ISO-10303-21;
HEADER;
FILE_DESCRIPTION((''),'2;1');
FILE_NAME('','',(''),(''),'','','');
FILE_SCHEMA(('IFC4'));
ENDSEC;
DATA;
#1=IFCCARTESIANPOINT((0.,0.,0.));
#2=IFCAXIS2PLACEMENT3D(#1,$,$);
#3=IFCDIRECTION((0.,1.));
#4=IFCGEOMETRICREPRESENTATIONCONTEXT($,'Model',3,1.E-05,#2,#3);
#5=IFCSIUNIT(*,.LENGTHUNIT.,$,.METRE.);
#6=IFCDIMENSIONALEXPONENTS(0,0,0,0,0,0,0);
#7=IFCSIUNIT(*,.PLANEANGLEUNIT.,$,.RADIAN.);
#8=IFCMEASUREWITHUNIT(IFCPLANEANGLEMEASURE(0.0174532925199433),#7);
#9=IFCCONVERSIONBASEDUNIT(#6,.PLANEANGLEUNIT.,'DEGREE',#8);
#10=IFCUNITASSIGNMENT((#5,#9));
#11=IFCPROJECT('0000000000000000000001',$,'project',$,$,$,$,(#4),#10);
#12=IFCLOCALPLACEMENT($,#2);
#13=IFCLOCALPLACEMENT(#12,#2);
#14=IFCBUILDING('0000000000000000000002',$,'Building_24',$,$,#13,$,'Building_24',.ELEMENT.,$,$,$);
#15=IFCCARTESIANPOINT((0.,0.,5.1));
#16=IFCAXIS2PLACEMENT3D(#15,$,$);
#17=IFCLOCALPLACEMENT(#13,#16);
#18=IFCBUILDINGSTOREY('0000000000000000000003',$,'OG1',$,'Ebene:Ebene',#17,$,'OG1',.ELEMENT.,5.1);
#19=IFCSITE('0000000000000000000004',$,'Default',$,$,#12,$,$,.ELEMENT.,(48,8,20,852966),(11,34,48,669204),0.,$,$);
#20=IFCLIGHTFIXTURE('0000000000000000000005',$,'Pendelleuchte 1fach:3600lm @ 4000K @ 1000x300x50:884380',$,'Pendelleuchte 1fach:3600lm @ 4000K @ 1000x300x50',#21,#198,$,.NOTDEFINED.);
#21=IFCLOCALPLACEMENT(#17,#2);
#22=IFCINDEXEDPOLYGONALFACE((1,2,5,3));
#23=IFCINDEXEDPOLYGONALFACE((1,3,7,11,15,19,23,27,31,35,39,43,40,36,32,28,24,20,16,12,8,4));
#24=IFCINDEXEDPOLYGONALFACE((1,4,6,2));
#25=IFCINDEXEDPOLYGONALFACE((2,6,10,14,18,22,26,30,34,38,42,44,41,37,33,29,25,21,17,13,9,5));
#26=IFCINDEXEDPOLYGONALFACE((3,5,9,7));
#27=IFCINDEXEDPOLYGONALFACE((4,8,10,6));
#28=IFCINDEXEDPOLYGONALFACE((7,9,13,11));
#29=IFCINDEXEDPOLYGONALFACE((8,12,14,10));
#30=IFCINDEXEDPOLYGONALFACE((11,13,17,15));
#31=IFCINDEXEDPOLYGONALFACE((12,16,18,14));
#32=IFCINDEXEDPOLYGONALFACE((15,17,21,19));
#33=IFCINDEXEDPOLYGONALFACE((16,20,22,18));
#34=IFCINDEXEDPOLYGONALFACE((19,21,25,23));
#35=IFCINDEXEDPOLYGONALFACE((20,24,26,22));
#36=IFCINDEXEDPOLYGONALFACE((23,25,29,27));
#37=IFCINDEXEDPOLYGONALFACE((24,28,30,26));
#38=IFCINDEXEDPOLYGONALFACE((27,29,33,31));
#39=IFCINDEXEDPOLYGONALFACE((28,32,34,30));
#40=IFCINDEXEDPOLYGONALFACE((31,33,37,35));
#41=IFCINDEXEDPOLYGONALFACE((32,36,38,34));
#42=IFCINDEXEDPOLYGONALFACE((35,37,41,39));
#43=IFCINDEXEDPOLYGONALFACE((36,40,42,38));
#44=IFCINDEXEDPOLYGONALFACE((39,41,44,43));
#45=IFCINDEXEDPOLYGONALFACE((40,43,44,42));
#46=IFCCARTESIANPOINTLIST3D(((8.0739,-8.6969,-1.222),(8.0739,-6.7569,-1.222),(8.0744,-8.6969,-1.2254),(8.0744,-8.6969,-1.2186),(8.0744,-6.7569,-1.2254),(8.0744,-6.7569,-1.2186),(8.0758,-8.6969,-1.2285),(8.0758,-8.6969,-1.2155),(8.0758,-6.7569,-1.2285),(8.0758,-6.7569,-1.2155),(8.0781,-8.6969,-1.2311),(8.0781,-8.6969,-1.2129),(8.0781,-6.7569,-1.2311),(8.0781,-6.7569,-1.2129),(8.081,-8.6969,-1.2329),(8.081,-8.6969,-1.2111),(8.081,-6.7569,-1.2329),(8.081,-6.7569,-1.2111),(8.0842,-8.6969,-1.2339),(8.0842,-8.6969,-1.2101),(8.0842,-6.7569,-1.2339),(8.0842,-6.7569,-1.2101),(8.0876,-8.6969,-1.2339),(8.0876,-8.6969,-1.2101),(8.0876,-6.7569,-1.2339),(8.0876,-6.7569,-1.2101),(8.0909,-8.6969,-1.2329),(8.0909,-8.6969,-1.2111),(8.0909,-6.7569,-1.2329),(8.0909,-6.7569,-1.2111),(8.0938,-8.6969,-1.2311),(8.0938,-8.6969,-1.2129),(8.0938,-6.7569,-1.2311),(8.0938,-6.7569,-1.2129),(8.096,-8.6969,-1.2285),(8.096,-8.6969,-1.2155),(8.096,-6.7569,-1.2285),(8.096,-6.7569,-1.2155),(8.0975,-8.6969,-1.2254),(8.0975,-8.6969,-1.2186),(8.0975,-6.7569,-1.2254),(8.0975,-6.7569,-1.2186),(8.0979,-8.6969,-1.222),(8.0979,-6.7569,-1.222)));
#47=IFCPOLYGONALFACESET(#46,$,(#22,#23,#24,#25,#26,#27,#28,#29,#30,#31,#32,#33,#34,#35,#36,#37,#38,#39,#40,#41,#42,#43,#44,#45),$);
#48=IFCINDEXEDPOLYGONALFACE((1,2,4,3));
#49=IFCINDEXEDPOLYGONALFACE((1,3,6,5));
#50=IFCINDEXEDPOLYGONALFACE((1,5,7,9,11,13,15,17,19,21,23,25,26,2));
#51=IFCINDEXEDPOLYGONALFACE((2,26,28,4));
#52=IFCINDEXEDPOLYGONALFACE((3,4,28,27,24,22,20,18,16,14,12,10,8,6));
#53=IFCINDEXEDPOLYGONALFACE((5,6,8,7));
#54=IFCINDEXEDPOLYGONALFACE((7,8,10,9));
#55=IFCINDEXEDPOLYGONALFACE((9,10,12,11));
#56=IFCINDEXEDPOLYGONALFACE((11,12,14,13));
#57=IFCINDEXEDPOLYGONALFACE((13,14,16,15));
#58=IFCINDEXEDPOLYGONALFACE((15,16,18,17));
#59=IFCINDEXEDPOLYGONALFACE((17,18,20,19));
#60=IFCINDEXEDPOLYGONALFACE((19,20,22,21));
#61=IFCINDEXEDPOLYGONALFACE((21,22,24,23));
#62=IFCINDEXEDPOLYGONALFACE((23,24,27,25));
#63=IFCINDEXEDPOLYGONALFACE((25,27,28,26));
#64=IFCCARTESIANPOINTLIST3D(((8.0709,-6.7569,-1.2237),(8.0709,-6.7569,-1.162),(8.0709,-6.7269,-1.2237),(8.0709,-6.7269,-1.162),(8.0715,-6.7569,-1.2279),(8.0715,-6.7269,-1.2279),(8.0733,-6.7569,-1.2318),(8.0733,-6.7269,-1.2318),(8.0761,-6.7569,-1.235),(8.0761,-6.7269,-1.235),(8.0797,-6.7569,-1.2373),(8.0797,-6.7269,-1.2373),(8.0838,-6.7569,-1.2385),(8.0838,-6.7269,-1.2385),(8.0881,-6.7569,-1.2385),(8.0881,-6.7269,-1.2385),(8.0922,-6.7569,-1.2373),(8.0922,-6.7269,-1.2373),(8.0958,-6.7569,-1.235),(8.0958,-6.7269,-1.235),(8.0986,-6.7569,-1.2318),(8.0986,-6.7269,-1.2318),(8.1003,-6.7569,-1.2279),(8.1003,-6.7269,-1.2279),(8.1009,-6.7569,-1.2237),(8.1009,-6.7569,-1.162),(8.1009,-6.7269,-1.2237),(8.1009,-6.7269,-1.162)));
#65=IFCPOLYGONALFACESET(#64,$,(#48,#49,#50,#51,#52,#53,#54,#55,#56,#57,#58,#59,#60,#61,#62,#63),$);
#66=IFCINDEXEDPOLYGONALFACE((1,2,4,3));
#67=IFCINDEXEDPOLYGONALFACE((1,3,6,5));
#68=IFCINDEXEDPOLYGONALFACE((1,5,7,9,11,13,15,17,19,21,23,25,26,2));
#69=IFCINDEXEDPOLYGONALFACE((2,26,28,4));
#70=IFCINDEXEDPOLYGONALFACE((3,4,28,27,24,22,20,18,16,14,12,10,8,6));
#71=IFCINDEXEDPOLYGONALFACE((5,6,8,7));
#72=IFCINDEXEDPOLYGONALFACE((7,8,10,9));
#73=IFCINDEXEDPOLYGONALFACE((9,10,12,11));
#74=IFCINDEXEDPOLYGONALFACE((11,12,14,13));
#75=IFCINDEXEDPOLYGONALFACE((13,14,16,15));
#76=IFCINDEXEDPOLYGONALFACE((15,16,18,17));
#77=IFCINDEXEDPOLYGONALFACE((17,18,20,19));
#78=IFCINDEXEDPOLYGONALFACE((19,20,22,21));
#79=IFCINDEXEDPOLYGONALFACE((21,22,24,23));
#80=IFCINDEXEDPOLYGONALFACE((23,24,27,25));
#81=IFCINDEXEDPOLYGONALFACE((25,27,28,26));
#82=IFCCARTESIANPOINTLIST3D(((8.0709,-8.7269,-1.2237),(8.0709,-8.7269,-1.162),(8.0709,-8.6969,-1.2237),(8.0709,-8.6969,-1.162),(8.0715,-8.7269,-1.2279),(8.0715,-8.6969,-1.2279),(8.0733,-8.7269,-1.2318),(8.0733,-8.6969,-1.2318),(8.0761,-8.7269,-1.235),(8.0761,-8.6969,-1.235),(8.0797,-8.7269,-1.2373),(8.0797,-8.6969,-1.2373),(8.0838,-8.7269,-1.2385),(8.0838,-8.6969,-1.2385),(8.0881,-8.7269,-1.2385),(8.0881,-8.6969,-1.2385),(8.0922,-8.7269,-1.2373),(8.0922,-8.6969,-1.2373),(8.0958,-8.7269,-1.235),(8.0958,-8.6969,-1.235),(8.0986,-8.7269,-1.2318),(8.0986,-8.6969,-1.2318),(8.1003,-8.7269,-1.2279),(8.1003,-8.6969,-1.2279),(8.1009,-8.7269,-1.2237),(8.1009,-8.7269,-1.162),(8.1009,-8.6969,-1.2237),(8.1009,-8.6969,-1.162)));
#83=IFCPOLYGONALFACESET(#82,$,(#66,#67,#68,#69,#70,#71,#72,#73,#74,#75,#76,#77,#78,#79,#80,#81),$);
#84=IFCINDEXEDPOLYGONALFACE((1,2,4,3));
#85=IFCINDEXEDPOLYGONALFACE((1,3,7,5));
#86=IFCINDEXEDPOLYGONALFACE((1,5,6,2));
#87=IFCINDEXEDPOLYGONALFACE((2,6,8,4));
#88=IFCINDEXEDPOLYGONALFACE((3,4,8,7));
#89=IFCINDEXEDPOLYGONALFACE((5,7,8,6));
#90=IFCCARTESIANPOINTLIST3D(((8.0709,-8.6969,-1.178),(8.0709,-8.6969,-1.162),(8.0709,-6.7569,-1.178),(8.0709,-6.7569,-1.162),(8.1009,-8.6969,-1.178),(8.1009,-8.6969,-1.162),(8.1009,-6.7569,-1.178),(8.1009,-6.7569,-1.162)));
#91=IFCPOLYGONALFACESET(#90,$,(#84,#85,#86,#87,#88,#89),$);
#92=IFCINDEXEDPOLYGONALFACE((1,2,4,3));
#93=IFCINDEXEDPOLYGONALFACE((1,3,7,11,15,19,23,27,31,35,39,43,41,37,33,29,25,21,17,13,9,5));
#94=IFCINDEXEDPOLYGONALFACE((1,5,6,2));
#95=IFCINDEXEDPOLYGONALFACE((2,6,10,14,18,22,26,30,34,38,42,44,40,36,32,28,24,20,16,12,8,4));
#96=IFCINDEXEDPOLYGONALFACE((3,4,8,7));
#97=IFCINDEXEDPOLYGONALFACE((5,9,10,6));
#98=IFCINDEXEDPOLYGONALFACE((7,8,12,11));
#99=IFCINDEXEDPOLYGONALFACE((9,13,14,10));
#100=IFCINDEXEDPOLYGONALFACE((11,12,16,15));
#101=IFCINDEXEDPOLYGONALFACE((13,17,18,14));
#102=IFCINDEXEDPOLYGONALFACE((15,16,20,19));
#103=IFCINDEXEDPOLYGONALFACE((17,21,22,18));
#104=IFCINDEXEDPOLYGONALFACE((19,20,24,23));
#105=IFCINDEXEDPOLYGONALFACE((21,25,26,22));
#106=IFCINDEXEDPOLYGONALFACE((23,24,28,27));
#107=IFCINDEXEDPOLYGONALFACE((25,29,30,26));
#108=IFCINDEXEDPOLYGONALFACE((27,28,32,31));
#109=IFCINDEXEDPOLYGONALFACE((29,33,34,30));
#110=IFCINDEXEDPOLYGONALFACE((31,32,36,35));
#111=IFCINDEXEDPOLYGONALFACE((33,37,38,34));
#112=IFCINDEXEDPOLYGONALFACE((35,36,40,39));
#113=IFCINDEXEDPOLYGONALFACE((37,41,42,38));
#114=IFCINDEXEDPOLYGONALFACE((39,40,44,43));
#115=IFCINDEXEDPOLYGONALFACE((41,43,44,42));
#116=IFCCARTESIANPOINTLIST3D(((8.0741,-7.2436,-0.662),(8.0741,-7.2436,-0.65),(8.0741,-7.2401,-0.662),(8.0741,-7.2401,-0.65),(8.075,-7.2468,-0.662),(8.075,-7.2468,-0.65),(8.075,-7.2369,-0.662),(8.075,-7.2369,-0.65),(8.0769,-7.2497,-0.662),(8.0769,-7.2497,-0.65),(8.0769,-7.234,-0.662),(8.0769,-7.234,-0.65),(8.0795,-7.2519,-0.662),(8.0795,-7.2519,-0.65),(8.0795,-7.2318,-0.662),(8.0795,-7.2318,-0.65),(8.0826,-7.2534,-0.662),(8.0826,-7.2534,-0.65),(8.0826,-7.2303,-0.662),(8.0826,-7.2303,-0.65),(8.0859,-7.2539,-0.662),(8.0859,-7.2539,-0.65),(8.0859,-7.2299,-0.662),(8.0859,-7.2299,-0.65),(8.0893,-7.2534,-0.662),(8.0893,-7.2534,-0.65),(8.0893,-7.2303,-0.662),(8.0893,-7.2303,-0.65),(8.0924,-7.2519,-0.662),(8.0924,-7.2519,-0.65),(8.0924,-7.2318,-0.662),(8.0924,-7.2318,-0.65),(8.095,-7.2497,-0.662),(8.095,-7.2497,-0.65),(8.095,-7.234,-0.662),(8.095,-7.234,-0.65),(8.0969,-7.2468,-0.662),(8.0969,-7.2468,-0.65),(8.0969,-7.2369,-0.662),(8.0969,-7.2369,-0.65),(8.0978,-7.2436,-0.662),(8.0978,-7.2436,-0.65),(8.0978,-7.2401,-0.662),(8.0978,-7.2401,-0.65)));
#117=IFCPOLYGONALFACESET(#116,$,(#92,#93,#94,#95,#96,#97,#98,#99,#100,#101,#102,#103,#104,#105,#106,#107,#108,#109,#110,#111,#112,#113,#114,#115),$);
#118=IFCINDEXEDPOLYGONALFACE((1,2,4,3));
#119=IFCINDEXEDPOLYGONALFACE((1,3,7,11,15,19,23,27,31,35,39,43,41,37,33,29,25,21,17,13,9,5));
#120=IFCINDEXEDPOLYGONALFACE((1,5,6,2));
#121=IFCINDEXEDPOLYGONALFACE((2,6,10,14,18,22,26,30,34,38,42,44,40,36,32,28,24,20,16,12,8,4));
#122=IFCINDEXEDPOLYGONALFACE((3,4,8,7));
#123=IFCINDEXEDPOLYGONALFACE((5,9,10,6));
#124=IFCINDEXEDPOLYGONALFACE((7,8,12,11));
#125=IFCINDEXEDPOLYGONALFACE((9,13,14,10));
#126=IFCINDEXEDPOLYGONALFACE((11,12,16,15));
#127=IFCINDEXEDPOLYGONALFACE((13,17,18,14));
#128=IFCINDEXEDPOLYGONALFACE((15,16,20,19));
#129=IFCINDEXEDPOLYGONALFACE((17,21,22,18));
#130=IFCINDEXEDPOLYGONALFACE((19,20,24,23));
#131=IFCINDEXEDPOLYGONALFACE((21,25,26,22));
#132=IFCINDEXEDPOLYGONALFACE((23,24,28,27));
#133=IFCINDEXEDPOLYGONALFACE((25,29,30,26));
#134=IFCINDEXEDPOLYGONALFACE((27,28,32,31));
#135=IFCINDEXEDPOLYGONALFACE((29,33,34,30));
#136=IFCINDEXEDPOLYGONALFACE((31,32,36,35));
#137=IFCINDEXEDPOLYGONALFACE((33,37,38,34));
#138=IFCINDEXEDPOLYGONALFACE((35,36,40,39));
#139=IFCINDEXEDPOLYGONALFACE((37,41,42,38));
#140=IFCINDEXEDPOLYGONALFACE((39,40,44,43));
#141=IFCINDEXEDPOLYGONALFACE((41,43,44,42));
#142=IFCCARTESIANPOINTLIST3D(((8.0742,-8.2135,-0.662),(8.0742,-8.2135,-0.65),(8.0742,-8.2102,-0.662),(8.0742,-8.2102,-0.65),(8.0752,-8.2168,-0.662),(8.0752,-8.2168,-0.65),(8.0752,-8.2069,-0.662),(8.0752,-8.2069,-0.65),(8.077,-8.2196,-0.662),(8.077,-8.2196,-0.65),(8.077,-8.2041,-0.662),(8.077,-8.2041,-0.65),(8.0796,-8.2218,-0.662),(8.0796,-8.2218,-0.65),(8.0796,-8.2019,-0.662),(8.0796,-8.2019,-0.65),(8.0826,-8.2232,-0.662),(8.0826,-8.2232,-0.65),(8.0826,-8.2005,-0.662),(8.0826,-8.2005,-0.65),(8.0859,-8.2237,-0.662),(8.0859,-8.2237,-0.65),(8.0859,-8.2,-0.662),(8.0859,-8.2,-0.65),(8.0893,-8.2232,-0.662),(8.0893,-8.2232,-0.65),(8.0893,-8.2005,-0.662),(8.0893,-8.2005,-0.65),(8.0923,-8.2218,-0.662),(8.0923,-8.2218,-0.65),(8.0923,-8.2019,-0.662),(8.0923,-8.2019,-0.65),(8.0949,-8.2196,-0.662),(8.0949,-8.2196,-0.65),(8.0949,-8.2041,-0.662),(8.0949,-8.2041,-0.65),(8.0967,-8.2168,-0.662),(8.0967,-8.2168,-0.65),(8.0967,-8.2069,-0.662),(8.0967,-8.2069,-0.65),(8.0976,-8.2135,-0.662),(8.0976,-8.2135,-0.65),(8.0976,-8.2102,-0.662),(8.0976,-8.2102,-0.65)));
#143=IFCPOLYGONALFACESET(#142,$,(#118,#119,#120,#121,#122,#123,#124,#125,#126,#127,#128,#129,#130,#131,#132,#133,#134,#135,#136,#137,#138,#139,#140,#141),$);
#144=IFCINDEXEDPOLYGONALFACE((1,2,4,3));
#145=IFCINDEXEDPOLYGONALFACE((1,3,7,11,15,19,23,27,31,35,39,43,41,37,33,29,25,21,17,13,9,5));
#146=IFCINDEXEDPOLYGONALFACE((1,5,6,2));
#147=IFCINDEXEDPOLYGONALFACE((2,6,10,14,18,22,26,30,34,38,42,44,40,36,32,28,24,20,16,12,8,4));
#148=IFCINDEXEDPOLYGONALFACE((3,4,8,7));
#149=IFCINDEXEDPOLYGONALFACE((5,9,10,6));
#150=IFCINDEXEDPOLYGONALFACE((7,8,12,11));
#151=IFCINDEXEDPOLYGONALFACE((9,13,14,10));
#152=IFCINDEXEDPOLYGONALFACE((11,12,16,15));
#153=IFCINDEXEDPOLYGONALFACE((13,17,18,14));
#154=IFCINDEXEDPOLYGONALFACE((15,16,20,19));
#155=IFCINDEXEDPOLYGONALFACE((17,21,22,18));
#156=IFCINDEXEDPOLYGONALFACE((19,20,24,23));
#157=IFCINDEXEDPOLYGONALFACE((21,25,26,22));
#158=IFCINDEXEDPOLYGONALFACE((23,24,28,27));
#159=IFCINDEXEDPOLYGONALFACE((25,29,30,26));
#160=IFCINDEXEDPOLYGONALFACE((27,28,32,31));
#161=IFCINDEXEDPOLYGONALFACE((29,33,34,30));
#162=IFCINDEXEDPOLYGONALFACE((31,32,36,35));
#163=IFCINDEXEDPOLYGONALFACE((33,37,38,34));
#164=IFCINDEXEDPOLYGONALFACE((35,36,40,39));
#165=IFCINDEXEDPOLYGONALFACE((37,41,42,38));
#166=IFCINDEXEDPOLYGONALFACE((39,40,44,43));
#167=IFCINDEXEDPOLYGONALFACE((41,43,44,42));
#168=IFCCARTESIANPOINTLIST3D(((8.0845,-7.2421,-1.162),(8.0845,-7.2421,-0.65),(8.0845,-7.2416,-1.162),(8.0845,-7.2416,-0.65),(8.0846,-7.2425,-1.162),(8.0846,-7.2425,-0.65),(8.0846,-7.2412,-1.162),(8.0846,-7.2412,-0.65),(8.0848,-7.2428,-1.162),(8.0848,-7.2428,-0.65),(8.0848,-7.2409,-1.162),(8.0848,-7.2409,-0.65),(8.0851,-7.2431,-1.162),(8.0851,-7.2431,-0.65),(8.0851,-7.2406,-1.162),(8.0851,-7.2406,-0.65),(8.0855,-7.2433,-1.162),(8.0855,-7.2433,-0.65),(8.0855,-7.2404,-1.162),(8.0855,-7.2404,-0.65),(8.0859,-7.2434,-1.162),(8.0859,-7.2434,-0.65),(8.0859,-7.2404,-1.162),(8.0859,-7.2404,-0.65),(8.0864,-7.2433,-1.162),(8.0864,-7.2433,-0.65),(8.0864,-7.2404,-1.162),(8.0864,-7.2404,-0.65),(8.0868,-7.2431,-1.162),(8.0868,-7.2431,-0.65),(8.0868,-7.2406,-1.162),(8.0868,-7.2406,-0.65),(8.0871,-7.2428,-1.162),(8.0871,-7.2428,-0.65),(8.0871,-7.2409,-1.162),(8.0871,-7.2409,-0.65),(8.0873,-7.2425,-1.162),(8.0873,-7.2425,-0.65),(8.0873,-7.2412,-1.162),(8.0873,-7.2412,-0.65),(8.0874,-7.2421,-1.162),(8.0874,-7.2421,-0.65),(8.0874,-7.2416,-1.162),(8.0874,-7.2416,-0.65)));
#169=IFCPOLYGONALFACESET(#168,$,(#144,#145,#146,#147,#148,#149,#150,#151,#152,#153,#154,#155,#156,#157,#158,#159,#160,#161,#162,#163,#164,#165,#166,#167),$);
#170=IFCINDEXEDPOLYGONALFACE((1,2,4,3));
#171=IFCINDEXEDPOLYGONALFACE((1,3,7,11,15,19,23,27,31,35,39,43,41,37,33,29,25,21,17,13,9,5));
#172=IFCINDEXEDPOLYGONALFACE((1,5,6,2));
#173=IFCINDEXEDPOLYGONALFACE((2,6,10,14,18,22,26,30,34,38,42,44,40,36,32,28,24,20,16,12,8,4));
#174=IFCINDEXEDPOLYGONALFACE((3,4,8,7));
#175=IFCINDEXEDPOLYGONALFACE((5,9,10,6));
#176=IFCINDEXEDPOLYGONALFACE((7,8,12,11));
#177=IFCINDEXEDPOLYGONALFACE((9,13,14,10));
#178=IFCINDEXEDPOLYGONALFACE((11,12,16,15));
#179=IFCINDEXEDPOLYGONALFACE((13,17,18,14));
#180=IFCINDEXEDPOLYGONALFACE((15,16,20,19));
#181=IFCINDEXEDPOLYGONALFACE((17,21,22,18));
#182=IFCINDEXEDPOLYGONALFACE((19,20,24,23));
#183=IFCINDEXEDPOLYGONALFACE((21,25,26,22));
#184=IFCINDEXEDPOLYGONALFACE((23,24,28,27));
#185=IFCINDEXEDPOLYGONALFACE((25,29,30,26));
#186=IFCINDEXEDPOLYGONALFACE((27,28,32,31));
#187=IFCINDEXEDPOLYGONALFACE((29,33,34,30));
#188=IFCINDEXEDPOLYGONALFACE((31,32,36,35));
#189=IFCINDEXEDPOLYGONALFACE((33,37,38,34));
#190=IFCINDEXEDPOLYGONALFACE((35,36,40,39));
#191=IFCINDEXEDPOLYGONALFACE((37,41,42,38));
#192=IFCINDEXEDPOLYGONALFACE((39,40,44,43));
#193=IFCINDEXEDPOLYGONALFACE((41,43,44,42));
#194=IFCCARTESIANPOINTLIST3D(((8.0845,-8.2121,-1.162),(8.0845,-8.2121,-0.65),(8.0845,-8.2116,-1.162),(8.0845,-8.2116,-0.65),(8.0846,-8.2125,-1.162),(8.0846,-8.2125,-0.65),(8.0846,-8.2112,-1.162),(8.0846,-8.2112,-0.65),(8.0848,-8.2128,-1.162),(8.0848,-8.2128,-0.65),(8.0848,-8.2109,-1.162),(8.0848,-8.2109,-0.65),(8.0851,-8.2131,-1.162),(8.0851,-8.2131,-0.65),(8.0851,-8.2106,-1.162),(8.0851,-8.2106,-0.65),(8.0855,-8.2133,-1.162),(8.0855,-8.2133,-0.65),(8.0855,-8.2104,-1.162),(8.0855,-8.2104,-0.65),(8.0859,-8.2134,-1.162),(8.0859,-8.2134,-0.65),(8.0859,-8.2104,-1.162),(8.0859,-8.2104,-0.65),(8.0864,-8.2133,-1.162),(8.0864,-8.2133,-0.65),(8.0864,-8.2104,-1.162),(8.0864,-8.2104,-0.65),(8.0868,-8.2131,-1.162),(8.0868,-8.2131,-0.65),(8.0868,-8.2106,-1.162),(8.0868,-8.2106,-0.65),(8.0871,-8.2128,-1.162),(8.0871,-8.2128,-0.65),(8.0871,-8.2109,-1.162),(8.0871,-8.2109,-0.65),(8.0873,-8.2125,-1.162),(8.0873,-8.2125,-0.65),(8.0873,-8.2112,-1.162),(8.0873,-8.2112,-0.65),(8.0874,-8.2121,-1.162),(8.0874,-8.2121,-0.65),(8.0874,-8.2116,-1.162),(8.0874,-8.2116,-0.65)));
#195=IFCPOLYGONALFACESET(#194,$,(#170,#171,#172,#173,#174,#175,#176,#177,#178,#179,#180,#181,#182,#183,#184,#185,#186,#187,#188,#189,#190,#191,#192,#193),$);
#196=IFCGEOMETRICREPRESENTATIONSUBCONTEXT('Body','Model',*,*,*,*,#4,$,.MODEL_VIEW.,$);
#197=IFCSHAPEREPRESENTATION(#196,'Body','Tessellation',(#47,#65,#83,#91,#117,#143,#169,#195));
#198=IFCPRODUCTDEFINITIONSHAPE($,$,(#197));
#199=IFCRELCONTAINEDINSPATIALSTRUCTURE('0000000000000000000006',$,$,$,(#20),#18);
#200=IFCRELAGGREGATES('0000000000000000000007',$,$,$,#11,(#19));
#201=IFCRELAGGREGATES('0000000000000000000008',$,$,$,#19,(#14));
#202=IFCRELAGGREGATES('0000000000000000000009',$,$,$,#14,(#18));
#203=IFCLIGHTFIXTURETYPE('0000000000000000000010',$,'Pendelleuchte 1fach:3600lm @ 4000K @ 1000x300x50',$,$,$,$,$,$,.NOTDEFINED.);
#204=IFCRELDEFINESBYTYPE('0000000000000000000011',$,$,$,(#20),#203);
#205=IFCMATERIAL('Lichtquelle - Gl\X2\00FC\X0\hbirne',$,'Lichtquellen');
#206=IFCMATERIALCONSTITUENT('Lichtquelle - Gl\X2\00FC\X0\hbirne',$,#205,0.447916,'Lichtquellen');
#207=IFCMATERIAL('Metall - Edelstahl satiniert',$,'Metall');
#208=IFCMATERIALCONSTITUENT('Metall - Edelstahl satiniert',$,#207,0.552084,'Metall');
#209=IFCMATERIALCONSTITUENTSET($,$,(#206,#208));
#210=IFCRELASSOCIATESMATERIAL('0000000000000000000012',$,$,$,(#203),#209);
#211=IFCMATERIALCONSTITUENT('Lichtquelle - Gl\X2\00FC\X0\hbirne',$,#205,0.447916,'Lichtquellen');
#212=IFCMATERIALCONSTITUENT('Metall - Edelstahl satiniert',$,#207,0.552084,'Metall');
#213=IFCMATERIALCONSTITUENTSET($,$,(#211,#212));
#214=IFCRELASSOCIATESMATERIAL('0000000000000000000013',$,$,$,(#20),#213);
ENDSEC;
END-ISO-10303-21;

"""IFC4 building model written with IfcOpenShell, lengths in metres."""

from ifc_helpers import new_model, entity, si_unit, converted_unit, direction, frame, origin, place, context, subcontext, project, spatial, line, arc, indexed_curve, outline, extrude, source, transform, mapped, material, constituent, constituent_set, type_object, type_shapes, element, save


model = new_model("IFC4")

# Units and contexts
model_context = context("Model", 3, precision=1e-05, world=origin(), true_north=direction((0.0, 1.0)))
body_context = subcontext(model_context, "Body", "Model", "MODEL_VIEW")
ifc_project = project(units=[si_unit("LENGTHUNIT", "METRE"), converted_unit("PLANEANGLEUNIT", "DEGREE", entity("IfcPlaneAngleMeasure", 0.0174532925199433), si_unit("PLANEANGLEUNIT", "RADIAN"), dimensions=[0, 0, 0, 0, 0, 0, 0])], contexts=[model_context])

# Site, building, storey
site_placement = place(None, origin())
site = spatial("IfcSite", under=ifc_project, at=site_placement, Name="Default", CompositionType="ELEMENT", RefLatitude=(48, 8, 20, 852966), RefLongitude=(11, 34, 48, 669204), RefElevation=0.0)
building_placement = place(site_placement, origin())
building = spatial("IfcBuilding", under=site, at=building_placement, Name="Building_24", LongName="Building_24", CompositionType="ELEMENT")
storey_placement = place(building_placement, frame((0.0, 0.0, 5.1)))
storey = spatial("IfcBuildingStorey", under=building, at=storey_placement, Name="OG1", ObjectType="Ebene:Ebene", LongName="OG1", CompositionType="ELEMENT", Elevation=5.1)

# Light fixture
ifc_material_1 = material(Name="Lichtquelle - Glühbirne", Category="Lichtquellen")
ifc_material_2 = material(Name="Metall - Edelstahl satiniert", Category="Metall")
ifc_constituent_1 = constituent(ifc_material_1, Name="Lichtquelle - Glühbirne", Category="Lichtquellen", fraction=0.447916)
ifc_constituent_2 = constituent(ifc_material_2, Name="Metall - Edelstahl satiniert", Category="Metall", fraction=0.552084)
ifc_constituent_set_1 = constituent_set(constituents=[ifc_constituent_1, ifc_constituent_2])
light_fixture_type_1 = type_object("IfcLightFixtureType", Name="Pendelleuchte 1fach:3600lm @ 4000K @ 1000x300x50", PredefinedType="NOTDEFINED", material=ifc_constituent_set_1)
shared_shape_1 = source(origin(), body_context, "Body", "SweptSolid", [
    extrude(outline(indexed_curve([(-0.012, 0.0), (0.0, -0.012), (0.012, 0.0), (0.0, 0.012)], segments=[arc(1, 2, 3), arc(3, 4, 1)], self_intersect=False)), frame((-0.97, 0.0, -0.572), z_axis=(1.0, 0.0, 0.0), x_axis=(0.0, 1.0, 0.0)), (0.0, 0.0, 1.0), 1.94),
    extrude(outline(indexed_curve([(-0.0308, -0.015), (0.0308, -0.015), (0.0308, 0.015), (-0.0308, 0.015), (-0.0458, 0.0)], segments=[line(1, 2, 3, 4), arc(4, 5, 1)], self_intersect=False)), frame((0.97, 0.0, -0.5428), z_axis=(1.0, 0.0, 0.0), x_axis=(0.0, 0.0, 1.0)), (0.0, 0.0, 1.0), 0.03),
    extrude(outline(indexed_curve([(-0.0308, -0.015), (0.0308, -0.015), (0.0308, 0.015), (-0.0308, 0.015), (-0.0458, 0.0)], segments=[line(1, 2, 3, 4), arc(4, 5, 1)], self_intersect=False)), frame((-1.0, 0.0, -0.5428), z_axis=(1.0, 0.0, 0.0), x_axis=(0.0, 0.0, 1.0)), (0.0, 0.0, 1.0), 0.03),
    extrude(outline(indexed_curve([(-0.97, -0.015), (0.97, -0.015), (0.97, 0.015), (-0.97, 0.015), (-0.97, -0.015)], self_intersect=False)), frame((0.0, 0.0, -0.528), z_axis=(0.0, 0.0, 1.0), x_axis=(-1.0, 0.0, 0.0)), (0.0, 0.0, 1.0), 0.016),
    extrude(outline(indexed_curve([(-0.012, 0.0), (0.0, -0.012), (0.012, 0.0), (0.0, 0.012)], segments=[arc(1, 2, 3), arc(3, 4, 1)], self_intersect=False)), frame((0.485, 0.0, -0.012)), (0.0, 0.0, 1.0), 0.012),
    extrude(outline(indexed_curve([(-0.0118, 0.0), (0.0, -0.0118), (0.0118, 0.0), (0.0, 0.0118)], segments=[arc(1, 2, 3), arc(3, 4, 1)], self_intersect=False)), frame((-0.485, 0.0, -0.012)), (0.0, 0.0, 1.0), 0.012),
    extrude(outline(indexed_curve([(-0.0015, 0.0), (0.0, -0.0015), (0.0015, 0.0), (0.0, 0.0015)], segments=[arc(1, 2, 3), arc(3, 4, 1)], self_intersect=False)), frame((0.485, 0.0, -0.512)), (0.0, 0.0, 1.0), 0.512),
    extrude(outline(indexed_curve([(-0.0015, 0.0), (0.0, -0.0015), (0.0015, 0.0), (0.0, 0.0015)], segments=[arc(1, 2, 3), arc(3, 4, 1)], self_intersect=False)), frame((-0.485, 0.0, -0.512)), (0.0, 0.0, 1.0), 0.512),
])
type_shapes(light_fixture_type_1, [shared_shape_1])
ifc_constituent_3 = constituent(ifc_material_1, Name="Lichtquelle - Glühbirne", Category="Lichtquellen", fraction=0.447916)
ifc_constituent_4 = constituent(ifc_material_2, Name="Metall - Edelstahl satiniert", Category="Metall", fraction=0.552084)
ifc_constituent_set_2 = constituent_set(constituents=[ifc_constituent_3, ifc_constituent_4])
light_fixture_1_placement = place(storey_placement, frame((8.0859, -7.7269, -0.65), z_axis=(0.0, 0.0, 1.0), x_axis=(0.0, 1.0, 0.0)))
element("IfcLightFixture", 1, at=light_fixture_1_placement, inside=storey, type_object=light_fixture_type_1, material=ifc_constituent_set_2, Name="Pendelleuchte 1fach:3600lm @ 4000K @ 1000x300x50:884380", ObjectType="Pendelleuchte 1fach:3600lm @ 4000K @ 1000x300x50", PredefinedType="NOTDEFINED", context=body_context, shape_type="MappedRepresentation", body=[
    mapped(shared_shape_1, transform((0.0, 0.0, 0.0), scale=1.0)),
])

save(model, "model.ifc")
